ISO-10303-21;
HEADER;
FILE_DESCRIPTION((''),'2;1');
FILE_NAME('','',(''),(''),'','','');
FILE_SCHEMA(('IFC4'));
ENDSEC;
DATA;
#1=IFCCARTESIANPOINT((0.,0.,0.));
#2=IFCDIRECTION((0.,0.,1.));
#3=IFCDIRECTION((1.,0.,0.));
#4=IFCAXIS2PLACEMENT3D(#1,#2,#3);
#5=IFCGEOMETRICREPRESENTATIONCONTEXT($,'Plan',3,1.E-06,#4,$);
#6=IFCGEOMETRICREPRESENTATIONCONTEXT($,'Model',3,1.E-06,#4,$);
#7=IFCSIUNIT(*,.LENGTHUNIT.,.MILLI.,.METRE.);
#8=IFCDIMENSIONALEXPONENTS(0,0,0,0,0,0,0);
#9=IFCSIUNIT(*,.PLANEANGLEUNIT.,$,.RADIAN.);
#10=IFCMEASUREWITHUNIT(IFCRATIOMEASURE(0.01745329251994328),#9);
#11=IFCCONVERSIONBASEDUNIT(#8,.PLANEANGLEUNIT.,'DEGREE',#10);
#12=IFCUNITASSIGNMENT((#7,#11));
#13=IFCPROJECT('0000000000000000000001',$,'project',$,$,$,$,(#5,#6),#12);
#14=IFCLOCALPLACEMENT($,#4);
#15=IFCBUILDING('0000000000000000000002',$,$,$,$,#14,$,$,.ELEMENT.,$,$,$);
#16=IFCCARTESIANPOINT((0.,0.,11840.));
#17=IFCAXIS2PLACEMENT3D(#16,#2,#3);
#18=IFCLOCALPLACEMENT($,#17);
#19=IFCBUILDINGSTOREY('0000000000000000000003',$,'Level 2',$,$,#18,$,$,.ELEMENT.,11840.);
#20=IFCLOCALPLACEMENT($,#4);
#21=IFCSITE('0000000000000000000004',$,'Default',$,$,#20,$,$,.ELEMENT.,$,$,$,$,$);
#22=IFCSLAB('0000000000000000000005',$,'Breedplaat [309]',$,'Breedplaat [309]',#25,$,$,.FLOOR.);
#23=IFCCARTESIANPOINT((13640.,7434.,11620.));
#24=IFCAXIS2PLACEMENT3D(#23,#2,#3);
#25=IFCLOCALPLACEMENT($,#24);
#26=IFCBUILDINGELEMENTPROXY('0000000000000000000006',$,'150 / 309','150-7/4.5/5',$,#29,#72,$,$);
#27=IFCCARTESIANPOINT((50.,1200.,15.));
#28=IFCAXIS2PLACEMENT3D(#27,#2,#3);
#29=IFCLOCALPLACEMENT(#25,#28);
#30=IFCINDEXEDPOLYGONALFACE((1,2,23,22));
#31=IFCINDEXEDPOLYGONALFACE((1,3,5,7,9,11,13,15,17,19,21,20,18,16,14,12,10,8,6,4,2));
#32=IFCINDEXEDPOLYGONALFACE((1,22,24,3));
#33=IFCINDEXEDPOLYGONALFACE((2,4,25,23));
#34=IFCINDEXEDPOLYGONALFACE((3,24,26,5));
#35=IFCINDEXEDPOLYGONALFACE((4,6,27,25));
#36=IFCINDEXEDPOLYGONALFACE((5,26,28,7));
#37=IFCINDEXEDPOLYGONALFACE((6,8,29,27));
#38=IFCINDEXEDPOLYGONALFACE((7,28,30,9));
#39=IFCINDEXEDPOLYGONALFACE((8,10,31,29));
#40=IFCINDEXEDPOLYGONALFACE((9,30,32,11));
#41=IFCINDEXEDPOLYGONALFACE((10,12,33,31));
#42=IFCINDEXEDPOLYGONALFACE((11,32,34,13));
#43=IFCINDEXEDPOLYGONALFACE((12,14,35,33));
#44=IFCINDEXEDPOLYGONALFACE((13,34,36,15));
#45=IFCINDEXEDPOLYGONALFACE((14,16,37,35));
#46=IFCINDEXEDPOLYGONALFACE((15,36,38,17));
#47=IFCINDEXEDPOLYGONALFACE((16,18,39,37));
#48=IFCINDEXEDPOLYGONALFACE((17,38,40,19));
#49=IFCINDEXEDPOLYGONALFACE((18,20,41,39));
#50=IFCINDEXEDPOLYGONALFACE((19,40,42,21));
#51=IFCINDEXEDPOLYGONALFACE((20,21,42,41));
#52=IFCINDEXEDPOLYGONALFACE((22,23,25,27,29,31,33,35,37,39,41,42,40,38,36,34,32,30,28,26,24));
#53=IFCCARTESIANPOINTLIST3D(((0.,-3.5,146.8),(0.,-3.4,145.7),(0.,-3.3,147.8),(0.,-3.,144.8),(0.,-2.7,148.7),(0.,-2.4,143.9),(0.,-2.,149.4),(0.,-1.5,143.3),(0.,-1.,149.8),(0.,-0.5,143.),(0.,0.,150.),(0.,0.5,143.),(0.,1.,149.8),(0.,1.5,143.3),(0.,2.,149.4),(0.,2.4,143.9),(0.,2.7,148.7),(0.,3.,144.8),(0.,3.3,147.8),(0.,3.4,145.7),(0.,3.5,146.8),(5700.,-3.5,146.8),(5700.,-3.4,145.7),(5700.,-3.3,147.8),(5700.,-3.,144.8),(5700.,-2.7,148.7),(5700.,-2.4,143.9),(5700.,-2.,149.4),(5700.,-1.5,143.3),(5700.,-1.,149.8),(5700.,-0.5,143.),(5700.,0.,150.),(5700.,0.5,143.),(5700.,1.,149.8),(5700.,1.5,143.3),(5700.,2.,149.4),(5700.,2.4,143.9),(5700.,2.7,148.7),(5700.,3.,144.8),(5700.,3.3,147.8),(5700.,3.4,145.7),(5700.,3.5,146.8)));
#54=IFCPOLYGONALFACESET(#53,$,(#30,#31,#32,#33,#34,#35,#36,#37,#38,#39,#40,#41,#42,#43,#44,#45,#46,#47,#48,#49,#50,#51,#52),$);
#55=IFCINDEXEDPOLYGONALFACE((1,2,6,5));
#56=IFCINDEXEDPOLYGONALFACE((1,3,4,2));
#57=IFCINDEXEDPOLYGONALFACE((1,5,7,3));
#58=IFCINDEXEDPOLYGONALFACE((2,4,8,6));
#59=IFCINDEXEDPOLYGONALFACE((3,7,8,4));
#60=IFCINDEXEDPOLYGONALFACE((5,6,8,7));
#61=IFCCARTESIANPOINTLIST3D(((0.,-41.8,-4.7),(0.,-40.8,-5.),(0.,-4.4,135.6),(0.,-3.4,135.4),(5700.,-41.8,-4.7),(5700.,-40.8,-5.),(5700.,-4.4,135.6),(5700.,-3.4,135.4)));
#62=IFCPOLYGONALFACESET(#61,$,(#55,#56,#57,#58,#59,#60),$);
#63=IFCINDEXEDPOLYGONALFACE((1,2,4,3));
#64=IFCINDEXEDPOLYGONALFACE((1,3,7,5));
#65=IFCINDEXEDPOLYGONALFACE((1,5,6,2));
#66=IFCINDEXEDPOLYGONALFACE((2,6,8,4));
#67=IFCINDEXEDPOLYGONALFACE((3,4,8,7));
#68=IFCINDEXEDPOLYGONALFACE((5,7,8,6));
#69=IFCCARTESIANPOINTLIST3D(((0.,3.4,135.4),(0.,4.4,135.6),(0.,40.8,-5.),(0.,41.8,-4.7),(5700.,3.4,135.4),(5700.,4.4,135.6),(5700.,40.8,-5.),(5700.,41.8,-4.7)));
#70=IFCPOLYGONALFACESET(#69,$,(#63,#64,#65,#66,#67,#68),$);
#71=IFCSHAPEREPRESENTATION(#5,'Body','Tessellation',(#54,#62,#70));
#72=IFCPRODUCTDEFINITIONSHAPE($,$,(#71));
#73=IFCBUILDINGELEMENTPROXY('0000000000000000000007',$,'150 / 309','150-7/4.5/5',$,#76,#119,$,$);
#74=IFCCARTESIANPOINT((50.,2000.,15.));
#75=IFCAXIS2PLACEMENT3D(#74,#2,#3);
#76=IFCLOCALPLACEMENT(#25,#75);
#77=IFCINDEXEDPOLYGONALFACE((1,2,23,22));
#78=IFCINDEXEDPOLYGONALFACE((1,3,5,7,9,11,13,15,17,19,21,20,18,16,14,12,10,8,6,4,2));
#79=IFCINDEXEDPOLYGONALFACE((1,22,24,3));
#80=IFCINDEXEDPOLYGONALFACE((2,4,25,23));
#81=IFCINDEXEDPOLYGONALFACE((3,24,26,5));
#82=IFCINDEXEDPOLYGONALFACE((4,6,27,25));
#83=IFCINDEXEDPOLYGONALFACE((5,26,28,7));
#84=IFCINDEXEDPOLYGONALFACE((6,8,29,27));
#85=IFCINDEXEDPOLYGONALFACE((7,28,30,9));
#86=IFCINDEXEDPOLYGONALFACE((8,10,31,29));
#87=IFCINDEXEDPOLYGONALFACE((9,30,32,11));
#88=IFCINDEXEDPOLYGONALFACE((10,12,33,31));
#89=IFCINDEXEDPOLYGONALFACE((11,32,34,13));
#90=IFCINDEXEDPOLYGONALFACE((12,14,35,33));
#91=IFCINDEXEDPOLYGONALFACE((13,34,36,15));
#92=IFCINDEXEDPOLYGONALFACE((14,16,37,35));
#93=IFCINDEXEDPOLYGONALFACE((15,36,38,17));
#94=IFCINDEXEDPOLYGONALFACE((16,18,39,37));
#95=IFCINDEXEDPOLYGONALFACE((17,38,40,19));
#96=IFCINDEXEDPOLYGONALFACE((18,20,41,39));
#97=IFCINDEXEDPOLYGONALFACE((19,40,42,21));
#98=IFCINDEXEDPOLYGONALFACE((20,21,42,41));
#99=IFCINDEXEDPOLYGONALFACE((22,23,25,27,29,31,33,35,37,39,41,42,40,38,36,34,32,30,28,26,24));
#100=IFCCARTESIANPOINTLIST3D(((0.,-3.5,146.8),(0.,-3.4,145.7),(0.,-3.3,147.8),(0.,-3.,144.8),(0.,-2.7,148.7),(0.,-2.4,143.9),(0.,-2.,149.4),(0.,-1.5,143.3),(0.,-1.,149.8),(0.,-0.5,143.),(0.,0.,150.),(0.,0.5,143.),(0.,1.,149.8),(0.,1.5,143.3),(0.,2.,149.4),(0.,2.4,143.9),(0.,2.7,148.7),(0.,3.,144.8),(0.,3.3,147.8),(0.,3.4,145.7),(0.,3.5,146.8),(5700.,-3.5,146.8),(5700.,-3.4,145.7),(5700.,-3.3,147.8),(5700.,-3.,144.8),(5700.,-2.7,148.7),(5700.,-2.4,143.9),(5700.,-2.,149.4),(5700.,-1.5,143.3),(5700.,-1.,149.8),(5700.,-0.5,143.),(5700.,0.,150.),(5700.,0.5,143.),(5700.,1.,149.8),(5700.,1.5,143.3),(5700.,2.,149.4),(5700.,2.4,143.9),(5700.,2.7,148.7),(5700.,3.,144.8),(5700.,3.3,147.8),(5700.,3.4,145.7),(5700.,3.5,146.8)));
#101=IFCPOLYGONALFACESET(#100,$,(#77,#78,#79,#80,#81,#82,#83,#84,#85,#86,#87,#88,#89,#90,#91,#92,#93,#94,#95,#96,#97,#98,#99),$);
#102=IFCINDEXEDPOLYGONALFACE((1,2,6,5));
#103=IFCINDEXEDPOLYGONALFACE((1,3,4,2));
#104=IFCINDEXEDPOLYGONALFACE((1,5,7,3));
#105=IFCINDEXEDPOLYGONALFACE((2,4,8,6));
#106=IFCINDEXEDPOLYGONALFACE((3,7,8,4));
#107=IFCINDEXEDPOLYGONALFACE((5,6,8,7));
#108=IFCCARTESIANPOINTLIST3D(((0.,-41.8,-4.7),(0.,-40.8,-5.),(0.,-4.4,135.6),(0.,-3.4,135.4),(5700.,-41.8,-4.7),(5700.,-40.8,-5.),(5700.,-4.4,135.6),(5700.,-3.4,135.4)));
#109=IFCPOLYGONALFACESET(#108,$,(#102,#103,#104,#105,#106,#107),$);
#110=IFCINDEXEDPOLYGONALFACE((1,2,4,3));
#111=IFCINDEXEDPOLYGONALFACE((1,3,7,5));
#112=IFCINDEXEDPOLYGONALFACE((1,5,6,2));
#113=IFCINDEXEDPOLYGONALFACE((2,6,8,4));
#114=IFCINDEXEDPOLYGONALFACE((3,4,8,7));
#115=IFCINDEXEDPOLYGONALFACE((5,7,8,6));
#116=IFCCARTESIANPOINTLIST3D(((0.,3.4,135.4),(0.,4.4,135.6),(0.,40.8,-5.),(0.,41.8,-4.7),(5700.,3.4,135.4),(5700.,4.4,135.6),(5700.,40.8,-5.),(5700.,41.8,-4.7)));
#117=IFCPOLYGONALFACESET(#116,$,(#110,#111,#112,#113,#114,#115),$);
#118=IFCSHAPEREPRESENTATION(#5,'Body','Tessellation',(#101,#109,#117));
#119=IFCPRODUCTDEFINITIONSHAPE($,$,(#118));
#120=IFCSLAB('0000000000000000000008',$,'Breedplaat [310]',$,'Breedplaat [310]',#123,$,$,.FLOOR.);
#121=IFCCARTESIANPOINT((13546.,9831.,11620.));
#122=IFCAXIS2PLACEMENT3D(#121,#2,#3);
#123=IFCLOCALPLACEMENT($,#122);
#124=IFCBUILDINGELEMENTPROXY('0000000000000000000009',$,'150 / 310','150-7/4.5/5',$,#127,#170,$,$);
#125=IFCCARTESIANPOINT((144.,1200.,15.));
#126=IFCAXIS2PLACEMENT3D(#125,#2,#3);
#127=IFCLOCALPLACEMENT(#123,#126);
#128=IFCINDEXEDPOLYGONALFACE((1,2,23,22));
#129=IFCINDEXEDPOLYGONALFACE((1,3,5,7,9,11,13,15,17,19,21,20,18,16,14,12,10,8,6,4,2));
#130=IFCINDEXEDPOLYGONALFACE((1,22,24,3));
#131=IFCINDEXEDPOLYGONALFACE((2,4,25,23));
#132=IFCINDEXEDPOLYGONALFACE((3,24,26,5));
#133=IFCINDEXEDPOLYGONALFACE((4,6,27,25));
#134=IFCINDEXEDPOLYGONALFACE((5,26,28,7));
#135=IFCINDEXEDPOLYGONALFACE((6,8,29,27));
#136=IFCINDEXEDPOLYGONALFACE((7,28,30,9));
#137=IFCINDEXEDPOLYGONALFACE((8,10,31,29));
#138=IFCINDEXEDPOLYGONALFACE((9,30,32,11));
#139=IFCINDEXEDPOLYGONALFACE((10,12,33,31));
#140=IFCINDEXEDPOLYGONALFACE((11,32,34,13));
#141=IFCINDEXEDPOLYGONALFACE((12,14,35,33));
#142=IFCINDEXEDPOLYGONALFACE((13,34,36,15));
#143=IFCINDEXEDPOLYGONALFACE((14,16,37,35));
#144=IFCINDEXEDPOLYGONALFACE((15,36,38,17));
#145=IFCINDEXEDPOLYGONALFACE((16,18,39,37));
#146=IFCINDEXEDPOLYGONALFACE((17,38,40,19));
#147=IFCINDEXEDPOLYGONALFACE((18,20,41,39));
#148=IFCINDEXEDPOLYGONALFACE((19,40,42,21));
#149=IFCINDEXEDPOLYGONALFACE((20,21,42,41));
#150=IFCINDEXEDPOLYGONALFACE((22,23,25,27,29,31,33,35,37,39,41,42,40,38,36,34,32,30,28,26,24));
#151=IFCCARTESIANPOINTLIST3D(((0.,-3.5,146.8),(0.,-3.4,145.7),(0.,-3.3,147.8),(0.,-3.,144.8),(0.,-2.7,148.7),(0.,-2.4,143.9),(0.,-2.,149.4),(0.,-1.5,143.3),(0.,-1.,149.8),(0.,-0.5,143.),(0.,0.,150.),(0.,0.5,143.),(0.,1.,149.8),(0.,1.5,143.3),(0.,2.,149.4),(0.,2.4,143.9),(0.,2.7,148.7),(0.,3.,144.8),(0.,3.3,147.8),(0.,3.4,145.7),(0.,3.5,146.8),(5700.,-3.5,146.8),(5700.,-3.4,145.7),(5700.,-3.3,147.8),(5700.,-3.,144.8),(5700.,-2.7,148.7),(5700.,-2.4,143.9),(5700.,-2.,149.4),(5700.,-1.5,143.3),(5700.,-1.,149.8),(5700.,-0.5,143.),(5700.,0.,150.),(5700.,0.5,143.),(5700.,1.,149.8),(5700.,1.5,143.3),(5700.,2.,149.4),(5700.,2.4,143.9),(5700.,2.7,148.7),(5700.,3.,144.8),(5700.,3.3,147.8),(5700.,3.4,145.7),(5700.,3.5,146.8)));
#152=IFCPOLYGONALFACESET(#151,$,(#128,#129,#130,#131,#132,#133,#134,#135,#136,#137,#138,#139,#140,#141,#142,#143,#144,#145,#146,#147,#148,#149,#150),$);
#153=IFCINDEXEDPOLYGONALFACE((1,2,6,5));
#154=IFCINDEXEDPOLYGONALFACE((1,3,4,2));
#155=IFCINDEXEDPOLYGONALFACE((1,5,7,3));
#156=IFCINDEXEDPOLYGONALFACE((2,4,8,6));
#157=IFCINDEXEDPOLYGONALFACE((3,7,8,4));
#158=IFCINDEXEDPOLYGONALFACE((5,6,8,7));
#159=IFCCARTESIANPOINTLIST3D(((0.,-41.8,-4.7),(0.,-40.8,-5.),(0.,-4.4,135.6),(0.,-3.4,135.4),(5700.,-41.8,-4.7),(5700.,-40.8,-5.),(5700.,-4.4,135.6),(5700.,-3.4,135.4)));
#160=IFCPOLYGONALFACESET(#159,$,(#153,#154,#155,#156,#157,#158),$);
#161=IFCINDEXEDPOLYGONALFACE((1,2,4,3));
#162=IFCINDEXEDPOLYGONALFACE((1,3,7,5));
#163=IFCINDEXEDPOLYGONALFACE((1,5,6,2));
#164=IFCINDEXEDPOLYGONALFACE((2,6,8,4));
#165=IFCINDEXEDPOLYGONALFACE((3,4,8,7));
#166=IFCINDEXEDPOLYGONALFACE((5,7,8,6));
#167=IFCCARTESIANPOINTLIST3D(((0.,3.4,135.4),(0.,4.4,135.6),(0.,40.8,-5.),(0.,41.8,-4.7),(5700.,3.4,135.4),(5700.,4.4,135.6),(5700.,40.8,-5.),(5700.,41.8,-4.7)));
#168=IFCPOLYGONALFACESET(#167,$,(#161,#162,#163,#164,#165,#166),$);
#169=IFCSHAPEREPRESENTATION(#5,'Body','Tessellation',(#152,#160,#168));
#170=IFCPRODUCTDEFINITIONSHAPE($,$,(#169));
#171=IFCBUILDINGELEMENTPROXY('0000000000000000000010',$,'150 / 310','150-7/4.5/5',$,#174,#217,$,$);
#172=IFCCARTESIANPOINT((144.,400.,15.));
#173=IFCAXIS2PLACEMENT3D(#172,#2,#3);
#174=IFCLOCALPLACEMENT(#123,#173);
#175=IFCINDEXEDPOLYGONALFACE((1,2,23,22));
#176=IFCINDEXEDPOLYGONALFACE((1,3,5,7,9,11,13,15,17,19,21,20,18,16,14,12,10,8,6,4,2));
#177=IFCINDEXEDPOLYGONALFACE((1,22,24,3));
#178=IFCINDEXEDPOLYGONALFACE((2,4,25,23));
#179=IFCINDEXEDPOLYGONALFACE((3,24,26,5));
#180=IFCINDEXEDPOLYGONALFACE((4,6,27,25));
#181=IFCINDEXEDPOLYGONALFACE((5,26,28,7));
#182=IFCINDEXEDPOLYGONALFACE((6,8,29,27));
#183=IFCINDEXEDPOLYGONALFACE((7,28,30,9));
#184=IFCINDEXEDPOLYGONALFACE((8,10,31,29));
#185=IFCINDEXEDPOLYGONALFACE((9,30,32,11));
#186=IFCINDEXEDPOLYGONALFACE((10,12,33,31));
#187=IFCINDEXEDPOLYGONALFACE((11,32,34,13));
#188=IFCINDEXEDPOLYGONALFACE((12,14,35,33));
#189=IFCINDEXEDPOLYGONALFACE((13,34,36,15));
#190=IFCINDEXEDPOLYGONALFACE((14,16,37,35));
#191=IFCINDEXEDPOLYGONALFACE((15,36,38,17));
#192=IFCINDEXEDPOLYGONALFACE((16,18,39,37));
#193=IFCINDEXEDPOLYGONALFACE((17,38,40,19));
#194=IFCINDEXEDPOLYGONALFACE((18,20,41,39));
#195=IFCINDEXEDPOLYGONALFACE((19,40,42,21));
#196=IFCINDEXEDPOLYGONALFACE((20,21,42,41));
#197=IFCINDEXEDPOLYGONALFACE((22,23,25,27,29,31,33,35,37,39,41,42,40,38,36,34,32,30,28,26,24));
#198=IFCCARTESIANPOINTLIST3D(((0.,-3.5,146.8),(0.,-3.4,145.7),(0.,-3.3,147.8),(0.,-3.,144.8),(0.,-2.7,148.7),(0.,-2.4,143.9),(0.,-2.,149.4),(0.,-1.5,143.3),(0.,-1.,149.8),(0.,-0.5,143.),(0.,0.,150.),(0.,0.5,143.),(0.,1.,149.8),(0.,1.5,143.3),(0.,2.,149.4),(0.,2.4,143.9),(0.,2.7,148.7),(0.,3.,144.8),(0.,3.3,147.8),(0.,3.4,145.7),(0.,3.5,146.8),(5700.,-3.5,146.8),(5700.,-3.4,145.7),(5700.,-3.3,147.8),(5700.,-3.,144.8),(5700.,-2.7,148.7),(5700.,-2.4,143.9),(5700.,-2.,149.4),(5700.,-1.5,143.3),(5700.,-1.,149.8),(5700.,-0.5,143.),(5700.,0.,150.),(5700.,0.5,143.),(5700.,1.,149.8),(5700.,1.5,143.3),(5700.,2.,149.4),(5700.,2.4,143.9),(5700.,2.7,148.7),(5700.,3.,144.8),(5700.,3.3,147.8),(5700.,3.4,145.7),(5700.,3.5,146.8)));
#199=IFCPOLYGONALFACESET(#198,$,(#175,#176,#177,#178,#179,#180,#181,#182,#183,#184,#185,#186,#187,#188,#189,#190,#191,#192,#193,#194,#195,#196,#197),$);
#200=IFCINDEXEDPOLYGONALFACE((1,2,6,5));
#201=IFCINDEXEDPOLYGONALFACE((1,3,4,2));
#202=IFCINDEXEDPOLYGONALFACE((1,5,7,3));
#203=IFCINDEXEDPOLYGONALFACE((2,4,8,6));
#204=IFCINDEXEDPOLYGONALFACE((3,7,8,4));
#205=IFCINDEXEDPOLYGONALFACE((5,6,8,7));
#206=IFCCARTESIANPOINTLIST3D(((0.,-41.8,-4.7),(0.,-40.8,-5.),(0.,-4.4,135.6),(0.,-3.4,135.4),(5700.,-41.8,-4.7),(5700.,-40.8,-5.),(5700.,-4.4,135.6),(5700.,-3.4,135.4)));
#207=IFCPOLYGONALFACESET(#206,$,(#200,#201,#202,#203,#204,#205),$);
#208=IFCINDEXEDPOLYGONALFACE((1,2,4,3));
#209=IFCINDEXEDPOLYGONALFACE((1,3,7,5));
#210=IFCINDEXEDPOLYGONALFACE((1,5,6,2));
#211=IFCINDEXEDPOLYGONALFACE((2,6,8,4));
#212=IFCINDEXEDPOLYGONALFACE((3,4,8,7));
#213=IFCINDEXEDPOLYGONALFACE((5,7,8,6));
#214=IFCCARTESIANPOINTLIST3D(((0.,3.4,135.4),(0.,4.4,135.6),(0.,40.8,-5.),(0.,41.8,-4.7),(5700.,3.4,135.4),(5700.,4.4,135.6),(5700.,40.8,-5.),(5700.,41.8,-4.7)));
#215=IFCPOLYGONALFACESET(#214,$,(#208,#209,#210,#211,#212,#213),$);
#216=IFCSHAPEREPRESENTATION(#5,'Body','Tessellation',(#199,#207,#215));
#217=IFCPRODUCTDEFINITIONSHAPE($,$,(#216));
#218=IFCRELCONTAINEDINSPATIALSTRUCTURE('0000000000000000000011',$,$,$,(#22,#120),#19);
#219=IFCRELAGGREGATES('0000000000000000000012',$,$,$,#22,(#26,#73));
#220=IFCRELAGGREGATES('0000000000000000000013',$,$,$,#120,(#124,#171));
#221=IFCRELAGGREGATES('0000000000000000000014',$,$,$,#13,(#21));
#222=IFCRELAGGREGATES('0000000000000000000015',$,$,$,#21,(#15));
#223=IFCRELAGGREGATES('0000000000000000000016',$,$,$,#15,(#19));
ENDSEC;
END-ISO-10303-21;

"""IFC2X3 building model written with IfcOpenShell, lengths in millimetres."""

from ifc_helpers import new_model, entity, si_unit, converted_unit, frame, origin_with_axes, origin_2d_with_axis, place, context, project, spatial, rectangle, circle, extrude, element, aggregate, save


model = new_model("IFC2X3")

# Units and contexts
plan_context = context("Plan", 3, precision=1e-06, world=origin_with_axes())
model_context = context("Model", 3, precision=1e-06, world=origin_with_axes())
ifc_project = project(units=[si_unit("LENGTHUNIT", "METRE", prefix="MILLI"), converted_unit("PLANEANGLEUNIT", "DEGREE", entity("IfcRatioMeasure", 0.01745329251994328), si_unit("PLANEANGLEUNIT", "RADIAN"), dimensions=[0, 0, 0, 0, 0, 0, 0])], contexts=[plan_context, model_context])

# Site, building, storey
site_placement = place(None, origin_with_axes())
site = spatial("IfcSite", under=ifc_project, at=site_placement, Name="Default", CompositionType="ELEMENT")
building_placement = place(None, origin_with_axes())
building = spatial("IfcBuilding", under=site, at=building_placement, CompositionType="ELEMENT")
storey_placement = place(None, frame((0.0, 0.0, 11840.0), z_axis=(0.0, 0.0, 1.0), x_axis=(1.0, 0.0, 0.0)))
storey = spatial("IfcBuildingStorey", under=building, at=storey_placement, Name="Level 2", CompositionType="ELEMENT", Elevation=11840.0)

# Slab, building element proxies
slab_1_placement = place(None, frame((13640.0, 7434.0, 11620.0), z_axis=(0.0, 0.0, 1.0), x_axis=(1.0, 0.0, 0.0)))
slab_1 = element("IfcSlab", 1, at=slab_1_placement, inside=storey, Name="Breedplaat [309]", ObjectType="Breedplaat [309]", PredefinedType="FLOOR")
proxy_1_placement = place(slab_1_placement, frame((50.0, 1200.0, 15.0), z_axis=(0.0, 0.0, 1.0), x_axis=(1.0, 0.0, 0.0)))
proxy_1 = element("IfcBuildingElementProxy", 2, at=proxy_1_placement, Name="150 / 309", Description="150-7/4.5/5", context=plan_context, shape_type="SweptSolid", body=[
    extrude(circle(Radius=3.5, at=origin_2d_with_axis()), frame((0.0, 0.0, 146.5), z_axis=(1.0, 0.0, 0.0), x_axis=(0.0, 0.0, 1.0)), (0.0, 0.0, 1.0), 5700.0),
    extrude(rectangle(XDim=145.2, YDim=1.0, at=origin_2d_with_axis()), frame((0.0, -22.6, 65.3), z_axis=(1.0, 0.0, 0.0), x_axis=(0.0, 0.257663, 0.966235)), (0.0, 0.0, 1.0), 5700.0),
    extrude(rectangle(XDim=145.2, YDim=1.0, at=origin_2d_with_axis()), frame((0.0, 22.6, 65.3), z_axis=(1.0, 0.0, 0.0), x_axis=(0.0, -0.257663, 0.966235)), (0.0, 0.0, 1.0), 5700.0),
])
proxy_2_placement = place(slab_1_placement, frame((50.0, 2000.0, 15.0), z_axis=(0.0, 0.0, 1.0), x_axis=(1.0, 0.0, 0.0)))
proxy_2 = element("IfcBuildingElementProxy", 3, at=proxy_2_placement, Name="150 / 309", Description="150-7/4.5/5", context=plan_context, shape_type="SweptSolid", body=[
    extrude(circle(Radius=3.5, at=origin_2d_with_axis()), frame((0.0, 0.0, 146.5), z_axis=(1.0, 0.0, 0.0), x_axis=(0.0, 0.0, 1.0)), (0.0, 0.0, 1.0), 5700.0),
    extrude(rectangle(XDim=145.2, YDim=1.0, at=origin_2d_with_axis()), frame((0.0, -22.6, 65.3), z_axis=(1.0, 0.0, 0.0), x_axis=(0.0, 0.257663, 0.966235)), (0.0, 0.0, 1.0), 5700.0),
    extrude(rectangle(XDim=145.2, YDim=1.0, at=origin_2d_with_axis()), frame((0.0, 22.6, 65.3), z_axis=(1.0, 0.0, 0.0), x_axis=(0.0, -0.257663, 0.966235)), (0.0, 0.0, 1.0), 5700.0),
])
aggregate(slab_1, [proxy_1, proxy_2])

# Slab, building element proxies
slab_2_placement = place(None, frame((13546.0, 9831.0, 11620.0), z_axis=(0.0, 0.0, 1.0), x_axis=(1.0, 0.0, 0.0)))
slab_2 = element("IfcSlab", 4, at=slab_2_placement, inside=storey, Name="Breedplaat [310]", ObjectType="Breedplaat [310]", PredefinedType="FLOOR")
proxy_3_placement = place(slab_2_placement, frame((144.0, 1200.0, 15.0), z_axis=(0.0, 0.0, 1.0), x_axis=(1.0, 0.0, 0.0)))
proxy_3 = element("IfcBuildingElementProxy", 5, at=proxy_3_placement, Name="150 / 310", Description="150-7/4.5/5", context=plan_context, shape_type="SweptSolid", body=[
    extrude(circle(Radius=3.5, at=origin_2d_with_axis()), frame((0.0, 0.0, 146.5), z_axis=(1.0, 0.0, 0.0), x_axis=(0.0, 0.0, 1.0)), (0.0, 0.0, 1.0), 5700.0),
    extrude(rectangle(XDim=145.2, YDim=1.0, at=origin_2d_with_axis()), frame((0.0, -22.6, 65.3), z_axis=(1.0, 0.0, 0.0), x_axis=(0.0, 0.257663, 0.966235)), (0.0, 0.0, 1.0), 5700.0),
    extrude(rectangle(XDim=145.2, YDim=1.0, at=origin_2d_with_axis()), frame((0.0, 22.6, 65.3), z_axis=(1.0, 0.0, 0.0), x_axis=(0.0, -0.257663, 0.966235)), (0.0, 0.0, 1.0), 5700.0),
])
proxy_4_placement = place(slab_2_placement, frame((144.0, 400.0, 15.0), z_axis=(0.0, 0.0, 1.0), x_axis=(1.0, 0.0, 0.0)))
proxy_4 = element("IfcBuildingElementProxy", 6, at=proxy_4_placement, Name="150 / 310", Description="150-7/4.5/5", context=plan_context, shape_type="SweptSolid", body=[
    extrude(circle(Radius=3.5, at=origin_2d_with_axis()), frame((0.0, 0.0, 146.5), z_axis=(1.0, 0.0, 0.0), x_axis=(0.0, 0.0, 1.0)), (0.0, 0.0, 1.0), 5700.0),
    extrude(rectangle(XDim=145.2, YDim=1.0, at=origin_2d_with_axis()), frame((0.0, -22.6, 65.3), z_axis=(1.0, 0.0, 0.0), x_axis=(0.0, 0.257663, 0.966235)), (0.0, 0.0, 1.0), 5700.0),
    extrude(rectangle(XDim=145.2, YDim=1.0, at=origin_2d_with_axis()), frame((0.0, 22.6, 65.3), z_axis=(1.0, 0.0, 0.0), x_axis=(0.0, -0.257663, 0.966235)), (0.0, 0.0, 1.0), 5700.0),
])
aggregate(slab_2, [proxy_3, proxy_4])

save(model, "model.ifc")
